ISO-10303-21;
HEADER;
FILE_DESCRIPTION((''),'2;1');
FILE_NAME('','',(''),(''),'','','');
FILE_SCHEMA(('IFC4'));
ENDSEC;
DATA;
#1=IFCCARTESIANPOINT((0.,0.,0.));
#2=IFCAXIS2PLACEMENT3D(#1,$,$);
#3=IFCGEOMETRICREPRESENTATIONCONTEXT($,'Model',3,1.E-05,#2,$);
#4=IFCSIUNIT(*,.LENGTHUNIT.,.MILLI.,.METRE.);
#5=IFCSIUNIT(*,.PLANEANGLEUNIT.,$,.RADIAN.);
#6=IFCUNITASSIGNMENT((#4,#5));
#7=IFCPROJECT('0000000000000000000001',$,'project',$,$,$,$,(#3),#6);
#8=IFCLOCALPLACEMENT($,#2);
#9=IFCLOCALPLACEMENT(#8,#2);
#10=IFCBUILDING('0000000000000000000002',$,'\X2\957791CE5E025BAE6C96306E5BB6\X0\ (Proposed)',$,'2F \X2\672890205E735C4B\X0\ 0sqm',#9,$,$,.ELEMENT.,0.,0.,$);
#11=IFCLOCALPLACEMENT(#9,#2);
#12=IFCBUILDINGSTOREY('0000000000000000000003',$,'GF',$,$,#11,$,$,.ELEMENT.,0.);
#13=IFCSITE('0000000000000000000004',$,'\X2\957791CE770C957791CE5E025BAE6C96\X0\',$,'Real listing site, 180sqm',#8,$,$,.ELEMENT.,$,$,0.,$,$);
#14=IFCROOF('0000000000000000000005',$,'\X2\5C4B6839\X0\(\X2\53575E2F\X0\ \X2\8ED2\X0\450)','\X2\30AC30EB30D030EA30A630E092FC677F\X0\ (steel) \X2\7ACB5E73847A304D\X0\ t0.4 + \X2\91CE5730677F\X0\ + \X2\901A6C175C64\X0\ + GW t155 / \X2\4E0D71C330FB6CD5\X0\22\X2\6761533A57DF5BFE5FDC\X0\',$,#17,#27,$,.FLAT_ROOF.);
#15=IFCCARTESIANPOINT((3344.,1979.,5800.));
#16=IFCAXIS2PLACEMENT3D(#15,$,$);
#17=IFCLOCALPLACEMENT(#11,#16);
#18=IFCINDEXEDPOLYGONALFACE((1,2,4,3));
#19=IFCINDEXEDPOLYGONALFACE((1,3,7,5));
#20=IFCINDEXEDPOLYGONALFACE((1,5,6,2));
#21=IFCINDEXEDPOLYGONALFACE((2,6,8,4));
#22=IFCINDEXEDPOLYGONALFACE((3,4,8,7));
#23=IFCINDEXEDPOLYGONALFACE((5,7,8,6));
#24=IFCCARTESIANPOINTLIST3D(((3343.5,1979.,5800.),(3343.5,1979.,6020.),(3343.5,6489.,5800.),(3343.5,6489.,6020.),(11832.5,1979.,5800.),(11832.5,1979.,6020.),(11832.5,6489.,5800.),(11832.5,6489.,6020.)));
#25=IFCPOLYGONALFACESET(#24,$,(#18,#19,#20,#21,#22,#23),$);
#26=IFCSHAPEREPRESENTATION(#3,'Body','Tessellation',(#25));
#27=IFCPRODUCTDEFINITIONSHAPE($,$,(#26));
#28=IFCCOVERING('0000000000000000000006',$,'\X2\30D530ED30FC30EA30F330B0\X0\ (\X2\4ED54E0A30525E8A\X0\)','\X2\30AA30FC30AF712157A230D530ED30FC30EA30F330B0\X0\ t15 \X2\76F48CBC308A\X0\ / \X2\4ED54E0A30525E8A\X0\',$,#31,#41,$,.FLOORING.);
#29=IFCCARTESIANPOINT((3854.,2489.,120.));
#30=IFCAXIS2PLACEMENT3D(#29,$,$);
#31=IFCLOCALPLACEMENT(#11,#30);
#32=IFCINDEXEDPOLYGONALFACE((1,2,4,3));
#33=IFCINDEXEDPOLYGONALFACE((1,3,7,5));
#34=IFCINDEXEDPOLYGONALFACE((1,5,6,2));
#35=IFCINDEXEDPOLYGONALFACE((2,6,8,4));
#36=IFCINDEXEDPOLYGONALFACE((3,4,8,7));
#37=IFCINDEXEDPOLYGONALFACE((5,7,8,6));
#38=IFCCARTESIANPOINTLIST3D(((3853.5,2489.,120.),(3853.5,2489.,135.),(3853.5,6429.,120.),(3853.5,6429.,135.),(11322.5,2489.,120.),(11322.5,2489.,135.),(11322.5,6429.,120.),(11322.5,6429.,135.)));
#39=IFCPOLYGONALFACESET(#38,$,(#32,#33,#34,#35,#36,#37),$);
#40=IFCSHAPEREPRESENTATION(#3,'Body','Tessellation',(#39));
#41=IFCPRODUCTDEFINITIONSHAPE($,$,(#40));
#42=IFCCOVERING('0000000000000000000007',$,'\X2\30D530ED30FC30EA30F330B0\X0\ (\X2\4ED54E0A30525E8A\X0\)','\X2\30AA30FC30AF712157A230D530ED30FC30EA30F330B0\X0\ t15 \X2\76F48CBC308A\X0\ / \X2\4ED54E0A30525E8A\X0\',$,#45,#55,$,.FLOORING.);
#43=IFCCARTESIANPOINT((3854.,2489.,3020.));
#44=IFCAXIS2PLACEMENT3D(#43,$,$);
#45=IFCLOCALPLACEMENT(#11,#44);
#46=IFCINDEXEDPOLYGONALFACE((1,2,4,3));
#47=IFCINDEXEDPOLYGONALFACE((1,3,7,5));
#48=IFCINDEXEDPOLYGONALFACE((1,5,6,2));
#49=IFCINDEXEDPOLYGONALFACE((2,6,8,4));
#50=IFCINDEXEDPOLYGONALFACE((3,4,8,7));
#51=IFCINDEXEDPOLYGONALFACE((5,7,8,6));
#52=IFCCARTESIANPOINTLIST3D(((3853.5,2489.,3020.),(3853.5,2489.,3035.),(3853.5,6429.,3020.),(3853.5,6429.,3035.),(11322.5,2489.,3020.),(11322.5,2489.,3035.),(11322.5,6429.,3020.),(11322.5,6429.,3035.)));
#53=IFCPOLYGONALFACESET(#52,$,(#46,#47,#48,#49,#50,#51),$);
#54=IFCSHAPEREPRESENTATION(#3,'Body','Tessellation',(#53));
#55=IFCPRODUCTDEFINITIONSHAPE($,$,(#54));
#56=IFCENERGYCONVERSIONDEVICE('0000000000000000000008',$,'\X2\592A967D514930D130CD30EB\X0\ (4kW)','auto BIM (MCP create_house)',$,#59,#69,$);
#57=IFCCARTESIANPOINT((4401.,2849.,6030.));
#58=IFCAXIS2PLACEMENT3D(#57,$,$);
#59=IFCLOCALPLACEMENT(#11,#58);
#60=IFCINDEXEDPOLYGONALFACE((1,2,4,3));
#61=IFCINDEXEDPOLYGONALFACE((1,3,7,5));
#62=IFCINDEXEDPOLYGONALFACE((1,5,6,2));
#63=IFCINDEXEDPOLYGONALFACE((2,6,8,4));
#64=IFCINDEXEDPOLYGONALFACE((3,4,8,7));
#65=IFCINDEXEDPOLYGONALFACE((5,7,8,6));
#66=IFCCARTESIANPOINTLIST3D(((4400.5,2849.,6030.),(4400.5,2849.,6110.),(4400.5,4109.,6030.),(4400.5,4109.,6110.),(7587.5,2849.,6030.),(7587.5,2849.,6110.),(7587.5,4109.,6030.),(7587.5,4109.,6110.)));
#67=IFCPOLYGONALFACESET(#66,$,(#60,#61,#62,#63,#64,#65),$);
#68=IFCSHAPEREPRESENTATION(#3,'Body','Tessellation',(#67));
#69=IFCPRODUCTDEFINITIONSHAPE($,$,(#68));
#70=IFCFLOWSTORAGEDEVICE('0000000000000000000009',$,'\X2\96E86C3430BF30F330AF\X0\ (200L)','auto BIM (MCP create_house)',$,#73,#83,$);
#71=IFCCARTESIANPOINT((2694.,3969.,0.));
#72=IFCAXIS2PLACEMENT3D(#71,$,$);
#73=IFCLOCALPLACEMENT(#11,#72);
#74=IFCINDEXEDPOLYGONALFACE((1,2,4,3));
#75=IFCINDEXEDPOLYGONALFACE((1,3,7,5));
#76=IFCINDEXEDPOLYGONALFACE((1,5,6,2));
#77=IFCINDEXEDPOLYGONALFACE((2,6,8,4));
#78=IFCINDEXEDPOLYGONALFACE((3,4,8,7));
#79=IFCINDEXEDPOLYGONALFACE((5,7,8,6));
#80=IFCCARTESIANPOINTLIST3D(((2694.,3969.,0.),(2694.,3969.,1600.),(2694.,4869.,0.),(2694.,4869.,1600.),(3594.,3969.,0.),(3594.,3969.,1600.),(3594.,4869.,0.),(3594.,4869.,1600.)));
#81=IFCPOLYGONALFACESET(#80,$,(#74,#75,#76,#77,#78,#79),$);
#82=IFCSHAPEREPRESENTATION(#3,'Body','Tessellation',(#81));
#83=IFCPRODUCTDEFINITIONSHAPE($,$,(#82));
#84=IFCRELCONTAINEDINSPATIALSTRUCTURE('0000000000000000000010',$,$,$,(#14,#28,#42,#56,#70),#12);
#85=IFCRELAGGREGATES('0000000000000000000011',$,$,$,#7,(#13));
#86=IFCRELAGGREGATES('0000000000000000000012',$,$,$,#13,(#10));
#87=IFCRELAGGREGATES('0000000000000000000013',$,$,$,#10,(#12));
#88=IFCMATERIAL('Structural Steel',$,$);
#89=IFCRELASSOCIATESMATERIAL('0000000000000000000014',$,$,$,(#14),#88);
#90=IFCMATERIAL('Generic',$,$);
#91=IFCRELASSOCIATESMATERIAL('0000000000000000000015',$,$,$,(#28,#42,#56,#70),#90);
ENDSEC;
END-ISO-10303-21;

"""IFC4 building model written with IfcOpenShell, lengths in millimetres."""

from ifc_helpers import new_model, si_unit, frame, frame_2d, origin, place, context, project, spatial, rectangle, extrude, material, element, save


model = new_model("IFC4")

# Units and contexts
model_context = context("Model", 3, precision=1e-05, world=origin())
ifc_project = project(units=[si_unit("LENGTHUNIT", "METRE", prefix="MILLI"), si_unit("PLANEANGLEUNIT", "RADIAN")], contexts=[model_context])

# Site, building, storey
site_placement = place(None, origin())
site = spatial("IfcSite", under=ifc_project, at=site_placement, Name="長野県長野市宮沖", ObjectType="Real listing site, 180sqm", CompositionType="ELEMENT", RefElevation=0.0)
building_placement = place(site_placement, origin())
building = spatial("IfcBuilding", under=site, at=building_placement, Name="長野市宮沖の家 (Proposed)", ObjectType="2F 木造平屋 0sqm", CompositionType="ELEMENT", ElevationOfRefHeight=0.0, ElevationOfTerrain=0.0)
storey_placement = place(building_placement, origin())
storey = spatial("IfcBuildingStorey", under=building, at=storey_placement, Name="GF", CompositionType="ELEMENT", Elevation=0.0)

# Roof
ifc_material_1 = material(Name="Structural Steel")
for number, where, name in (
    (1, (3344.0, 1979.0, 5800.0), "屋根(南帯 軒450)"),
):
    element("IfcRoof", number, at=place(storey_placement, frame(where)), inside=storey, material=ifc_material_1, Name=name, Description="ガルバリウム鋼板 (steel) 立平葺き t0.4 + 野地板 + 通気層 + GW t155 / 不燃・法22条区域対応", PredefinedType="FLAT_ROOF", context=model_context, shape_type="SweptSolid", body=[
        extrude(rectangle(XDim=8489.0, YDim=4510.0, at=frame_2d((4244.0, 2255.0))), frame((3344.0, 1979.0, 5800.0)), (0.0, 0.0, 1.0), 220.0),
    ])

# Coverings
ifc_material_2 = material(Name="Generic")
covering_1_placement = place(storey_placement, frame((3854.0, 2489.0, 120.0)))
element("IfcCovering", 2, at=covering_1_placement, inside=storey, material=ifc_material_2, Name="フローリング (仕上げ床)", Description="オーク無垢フローリング t15 直貼り / 仕上げ床", PredefinedType="FLOORING", context=model_context, shape_type="SweptSolid", body=[
    extrude(rectangle(XDim=7469.0, YDim=3940.0, at=frame_2d((3734.0, 1970.0))), frame((3854.0, 2489.0, 120.0)), (0.0, 0.0, 1.0), 15.0),
])
covering_2_placement = place(storey_placement, frame((3854.0, 2489.0, 3020.0)))
element("IfcCovering", 3, at=covering_2_placement, inside=storey, material=ifc_material_2, Name="フローリング (仕上げ床)", Description="オーク無垢フローリング t15 直貼り / 仕上げ床", PredefinedType="FLOORING", context=model_context, shape_type="SweptSolid", body=[
    extrude(rectangle(XDim=7469.0, YDim=3940.0, at=frame_2d((3734.0, 1970.0))), frame((3854.0, 2489.0, 3020.0)), (0.0, 0.0, 1.0), 15.0),
])

# Energy conversion device
energy_conversion_device_placement = place(storey_placement, frame((4401.0, 2849.0, 6030.0)))
element("IfcEnergyConversionDevice", 4, at=energy_conversion_device_placement, inside=storey, material=ifc_material_2, Name="太陽光パネル (4kW)", Description="auto BIM (MCP create_house)", context=model_context, shape_type="SweptSolid", body=[
    extrude(rectangle(XDim=3187.0, YDim=1260.0, at=frame_2d((1593.0, 630.0))), frame((4401.0, 2849.0, 6030.0)), (0.0, 0.0, 1.0), 80.0),
])

# Flow storage device
flow_storage_device_placement = place(storey_placement, frame((2694.0, 3969.0, 0.0)))
element("IfcFlowStorageDevice", 5, at=flow_storage_device_placement, inside=storey, material=ifc_material_2, Name="雨水タンク (200L)", Description="auto BIM (MCP create_house)", context=model_context, shape_type="SweptSolid", body=[
    extrude(rectangle(XDim=900.0, YDim=900.0, at=frame_2d((450.0, 450.0))), frame((2694.0, 3969.0, 0.0)), (0.0, 0.0, 1.0), 1600.0),
])

save(model, "model.ifc")
